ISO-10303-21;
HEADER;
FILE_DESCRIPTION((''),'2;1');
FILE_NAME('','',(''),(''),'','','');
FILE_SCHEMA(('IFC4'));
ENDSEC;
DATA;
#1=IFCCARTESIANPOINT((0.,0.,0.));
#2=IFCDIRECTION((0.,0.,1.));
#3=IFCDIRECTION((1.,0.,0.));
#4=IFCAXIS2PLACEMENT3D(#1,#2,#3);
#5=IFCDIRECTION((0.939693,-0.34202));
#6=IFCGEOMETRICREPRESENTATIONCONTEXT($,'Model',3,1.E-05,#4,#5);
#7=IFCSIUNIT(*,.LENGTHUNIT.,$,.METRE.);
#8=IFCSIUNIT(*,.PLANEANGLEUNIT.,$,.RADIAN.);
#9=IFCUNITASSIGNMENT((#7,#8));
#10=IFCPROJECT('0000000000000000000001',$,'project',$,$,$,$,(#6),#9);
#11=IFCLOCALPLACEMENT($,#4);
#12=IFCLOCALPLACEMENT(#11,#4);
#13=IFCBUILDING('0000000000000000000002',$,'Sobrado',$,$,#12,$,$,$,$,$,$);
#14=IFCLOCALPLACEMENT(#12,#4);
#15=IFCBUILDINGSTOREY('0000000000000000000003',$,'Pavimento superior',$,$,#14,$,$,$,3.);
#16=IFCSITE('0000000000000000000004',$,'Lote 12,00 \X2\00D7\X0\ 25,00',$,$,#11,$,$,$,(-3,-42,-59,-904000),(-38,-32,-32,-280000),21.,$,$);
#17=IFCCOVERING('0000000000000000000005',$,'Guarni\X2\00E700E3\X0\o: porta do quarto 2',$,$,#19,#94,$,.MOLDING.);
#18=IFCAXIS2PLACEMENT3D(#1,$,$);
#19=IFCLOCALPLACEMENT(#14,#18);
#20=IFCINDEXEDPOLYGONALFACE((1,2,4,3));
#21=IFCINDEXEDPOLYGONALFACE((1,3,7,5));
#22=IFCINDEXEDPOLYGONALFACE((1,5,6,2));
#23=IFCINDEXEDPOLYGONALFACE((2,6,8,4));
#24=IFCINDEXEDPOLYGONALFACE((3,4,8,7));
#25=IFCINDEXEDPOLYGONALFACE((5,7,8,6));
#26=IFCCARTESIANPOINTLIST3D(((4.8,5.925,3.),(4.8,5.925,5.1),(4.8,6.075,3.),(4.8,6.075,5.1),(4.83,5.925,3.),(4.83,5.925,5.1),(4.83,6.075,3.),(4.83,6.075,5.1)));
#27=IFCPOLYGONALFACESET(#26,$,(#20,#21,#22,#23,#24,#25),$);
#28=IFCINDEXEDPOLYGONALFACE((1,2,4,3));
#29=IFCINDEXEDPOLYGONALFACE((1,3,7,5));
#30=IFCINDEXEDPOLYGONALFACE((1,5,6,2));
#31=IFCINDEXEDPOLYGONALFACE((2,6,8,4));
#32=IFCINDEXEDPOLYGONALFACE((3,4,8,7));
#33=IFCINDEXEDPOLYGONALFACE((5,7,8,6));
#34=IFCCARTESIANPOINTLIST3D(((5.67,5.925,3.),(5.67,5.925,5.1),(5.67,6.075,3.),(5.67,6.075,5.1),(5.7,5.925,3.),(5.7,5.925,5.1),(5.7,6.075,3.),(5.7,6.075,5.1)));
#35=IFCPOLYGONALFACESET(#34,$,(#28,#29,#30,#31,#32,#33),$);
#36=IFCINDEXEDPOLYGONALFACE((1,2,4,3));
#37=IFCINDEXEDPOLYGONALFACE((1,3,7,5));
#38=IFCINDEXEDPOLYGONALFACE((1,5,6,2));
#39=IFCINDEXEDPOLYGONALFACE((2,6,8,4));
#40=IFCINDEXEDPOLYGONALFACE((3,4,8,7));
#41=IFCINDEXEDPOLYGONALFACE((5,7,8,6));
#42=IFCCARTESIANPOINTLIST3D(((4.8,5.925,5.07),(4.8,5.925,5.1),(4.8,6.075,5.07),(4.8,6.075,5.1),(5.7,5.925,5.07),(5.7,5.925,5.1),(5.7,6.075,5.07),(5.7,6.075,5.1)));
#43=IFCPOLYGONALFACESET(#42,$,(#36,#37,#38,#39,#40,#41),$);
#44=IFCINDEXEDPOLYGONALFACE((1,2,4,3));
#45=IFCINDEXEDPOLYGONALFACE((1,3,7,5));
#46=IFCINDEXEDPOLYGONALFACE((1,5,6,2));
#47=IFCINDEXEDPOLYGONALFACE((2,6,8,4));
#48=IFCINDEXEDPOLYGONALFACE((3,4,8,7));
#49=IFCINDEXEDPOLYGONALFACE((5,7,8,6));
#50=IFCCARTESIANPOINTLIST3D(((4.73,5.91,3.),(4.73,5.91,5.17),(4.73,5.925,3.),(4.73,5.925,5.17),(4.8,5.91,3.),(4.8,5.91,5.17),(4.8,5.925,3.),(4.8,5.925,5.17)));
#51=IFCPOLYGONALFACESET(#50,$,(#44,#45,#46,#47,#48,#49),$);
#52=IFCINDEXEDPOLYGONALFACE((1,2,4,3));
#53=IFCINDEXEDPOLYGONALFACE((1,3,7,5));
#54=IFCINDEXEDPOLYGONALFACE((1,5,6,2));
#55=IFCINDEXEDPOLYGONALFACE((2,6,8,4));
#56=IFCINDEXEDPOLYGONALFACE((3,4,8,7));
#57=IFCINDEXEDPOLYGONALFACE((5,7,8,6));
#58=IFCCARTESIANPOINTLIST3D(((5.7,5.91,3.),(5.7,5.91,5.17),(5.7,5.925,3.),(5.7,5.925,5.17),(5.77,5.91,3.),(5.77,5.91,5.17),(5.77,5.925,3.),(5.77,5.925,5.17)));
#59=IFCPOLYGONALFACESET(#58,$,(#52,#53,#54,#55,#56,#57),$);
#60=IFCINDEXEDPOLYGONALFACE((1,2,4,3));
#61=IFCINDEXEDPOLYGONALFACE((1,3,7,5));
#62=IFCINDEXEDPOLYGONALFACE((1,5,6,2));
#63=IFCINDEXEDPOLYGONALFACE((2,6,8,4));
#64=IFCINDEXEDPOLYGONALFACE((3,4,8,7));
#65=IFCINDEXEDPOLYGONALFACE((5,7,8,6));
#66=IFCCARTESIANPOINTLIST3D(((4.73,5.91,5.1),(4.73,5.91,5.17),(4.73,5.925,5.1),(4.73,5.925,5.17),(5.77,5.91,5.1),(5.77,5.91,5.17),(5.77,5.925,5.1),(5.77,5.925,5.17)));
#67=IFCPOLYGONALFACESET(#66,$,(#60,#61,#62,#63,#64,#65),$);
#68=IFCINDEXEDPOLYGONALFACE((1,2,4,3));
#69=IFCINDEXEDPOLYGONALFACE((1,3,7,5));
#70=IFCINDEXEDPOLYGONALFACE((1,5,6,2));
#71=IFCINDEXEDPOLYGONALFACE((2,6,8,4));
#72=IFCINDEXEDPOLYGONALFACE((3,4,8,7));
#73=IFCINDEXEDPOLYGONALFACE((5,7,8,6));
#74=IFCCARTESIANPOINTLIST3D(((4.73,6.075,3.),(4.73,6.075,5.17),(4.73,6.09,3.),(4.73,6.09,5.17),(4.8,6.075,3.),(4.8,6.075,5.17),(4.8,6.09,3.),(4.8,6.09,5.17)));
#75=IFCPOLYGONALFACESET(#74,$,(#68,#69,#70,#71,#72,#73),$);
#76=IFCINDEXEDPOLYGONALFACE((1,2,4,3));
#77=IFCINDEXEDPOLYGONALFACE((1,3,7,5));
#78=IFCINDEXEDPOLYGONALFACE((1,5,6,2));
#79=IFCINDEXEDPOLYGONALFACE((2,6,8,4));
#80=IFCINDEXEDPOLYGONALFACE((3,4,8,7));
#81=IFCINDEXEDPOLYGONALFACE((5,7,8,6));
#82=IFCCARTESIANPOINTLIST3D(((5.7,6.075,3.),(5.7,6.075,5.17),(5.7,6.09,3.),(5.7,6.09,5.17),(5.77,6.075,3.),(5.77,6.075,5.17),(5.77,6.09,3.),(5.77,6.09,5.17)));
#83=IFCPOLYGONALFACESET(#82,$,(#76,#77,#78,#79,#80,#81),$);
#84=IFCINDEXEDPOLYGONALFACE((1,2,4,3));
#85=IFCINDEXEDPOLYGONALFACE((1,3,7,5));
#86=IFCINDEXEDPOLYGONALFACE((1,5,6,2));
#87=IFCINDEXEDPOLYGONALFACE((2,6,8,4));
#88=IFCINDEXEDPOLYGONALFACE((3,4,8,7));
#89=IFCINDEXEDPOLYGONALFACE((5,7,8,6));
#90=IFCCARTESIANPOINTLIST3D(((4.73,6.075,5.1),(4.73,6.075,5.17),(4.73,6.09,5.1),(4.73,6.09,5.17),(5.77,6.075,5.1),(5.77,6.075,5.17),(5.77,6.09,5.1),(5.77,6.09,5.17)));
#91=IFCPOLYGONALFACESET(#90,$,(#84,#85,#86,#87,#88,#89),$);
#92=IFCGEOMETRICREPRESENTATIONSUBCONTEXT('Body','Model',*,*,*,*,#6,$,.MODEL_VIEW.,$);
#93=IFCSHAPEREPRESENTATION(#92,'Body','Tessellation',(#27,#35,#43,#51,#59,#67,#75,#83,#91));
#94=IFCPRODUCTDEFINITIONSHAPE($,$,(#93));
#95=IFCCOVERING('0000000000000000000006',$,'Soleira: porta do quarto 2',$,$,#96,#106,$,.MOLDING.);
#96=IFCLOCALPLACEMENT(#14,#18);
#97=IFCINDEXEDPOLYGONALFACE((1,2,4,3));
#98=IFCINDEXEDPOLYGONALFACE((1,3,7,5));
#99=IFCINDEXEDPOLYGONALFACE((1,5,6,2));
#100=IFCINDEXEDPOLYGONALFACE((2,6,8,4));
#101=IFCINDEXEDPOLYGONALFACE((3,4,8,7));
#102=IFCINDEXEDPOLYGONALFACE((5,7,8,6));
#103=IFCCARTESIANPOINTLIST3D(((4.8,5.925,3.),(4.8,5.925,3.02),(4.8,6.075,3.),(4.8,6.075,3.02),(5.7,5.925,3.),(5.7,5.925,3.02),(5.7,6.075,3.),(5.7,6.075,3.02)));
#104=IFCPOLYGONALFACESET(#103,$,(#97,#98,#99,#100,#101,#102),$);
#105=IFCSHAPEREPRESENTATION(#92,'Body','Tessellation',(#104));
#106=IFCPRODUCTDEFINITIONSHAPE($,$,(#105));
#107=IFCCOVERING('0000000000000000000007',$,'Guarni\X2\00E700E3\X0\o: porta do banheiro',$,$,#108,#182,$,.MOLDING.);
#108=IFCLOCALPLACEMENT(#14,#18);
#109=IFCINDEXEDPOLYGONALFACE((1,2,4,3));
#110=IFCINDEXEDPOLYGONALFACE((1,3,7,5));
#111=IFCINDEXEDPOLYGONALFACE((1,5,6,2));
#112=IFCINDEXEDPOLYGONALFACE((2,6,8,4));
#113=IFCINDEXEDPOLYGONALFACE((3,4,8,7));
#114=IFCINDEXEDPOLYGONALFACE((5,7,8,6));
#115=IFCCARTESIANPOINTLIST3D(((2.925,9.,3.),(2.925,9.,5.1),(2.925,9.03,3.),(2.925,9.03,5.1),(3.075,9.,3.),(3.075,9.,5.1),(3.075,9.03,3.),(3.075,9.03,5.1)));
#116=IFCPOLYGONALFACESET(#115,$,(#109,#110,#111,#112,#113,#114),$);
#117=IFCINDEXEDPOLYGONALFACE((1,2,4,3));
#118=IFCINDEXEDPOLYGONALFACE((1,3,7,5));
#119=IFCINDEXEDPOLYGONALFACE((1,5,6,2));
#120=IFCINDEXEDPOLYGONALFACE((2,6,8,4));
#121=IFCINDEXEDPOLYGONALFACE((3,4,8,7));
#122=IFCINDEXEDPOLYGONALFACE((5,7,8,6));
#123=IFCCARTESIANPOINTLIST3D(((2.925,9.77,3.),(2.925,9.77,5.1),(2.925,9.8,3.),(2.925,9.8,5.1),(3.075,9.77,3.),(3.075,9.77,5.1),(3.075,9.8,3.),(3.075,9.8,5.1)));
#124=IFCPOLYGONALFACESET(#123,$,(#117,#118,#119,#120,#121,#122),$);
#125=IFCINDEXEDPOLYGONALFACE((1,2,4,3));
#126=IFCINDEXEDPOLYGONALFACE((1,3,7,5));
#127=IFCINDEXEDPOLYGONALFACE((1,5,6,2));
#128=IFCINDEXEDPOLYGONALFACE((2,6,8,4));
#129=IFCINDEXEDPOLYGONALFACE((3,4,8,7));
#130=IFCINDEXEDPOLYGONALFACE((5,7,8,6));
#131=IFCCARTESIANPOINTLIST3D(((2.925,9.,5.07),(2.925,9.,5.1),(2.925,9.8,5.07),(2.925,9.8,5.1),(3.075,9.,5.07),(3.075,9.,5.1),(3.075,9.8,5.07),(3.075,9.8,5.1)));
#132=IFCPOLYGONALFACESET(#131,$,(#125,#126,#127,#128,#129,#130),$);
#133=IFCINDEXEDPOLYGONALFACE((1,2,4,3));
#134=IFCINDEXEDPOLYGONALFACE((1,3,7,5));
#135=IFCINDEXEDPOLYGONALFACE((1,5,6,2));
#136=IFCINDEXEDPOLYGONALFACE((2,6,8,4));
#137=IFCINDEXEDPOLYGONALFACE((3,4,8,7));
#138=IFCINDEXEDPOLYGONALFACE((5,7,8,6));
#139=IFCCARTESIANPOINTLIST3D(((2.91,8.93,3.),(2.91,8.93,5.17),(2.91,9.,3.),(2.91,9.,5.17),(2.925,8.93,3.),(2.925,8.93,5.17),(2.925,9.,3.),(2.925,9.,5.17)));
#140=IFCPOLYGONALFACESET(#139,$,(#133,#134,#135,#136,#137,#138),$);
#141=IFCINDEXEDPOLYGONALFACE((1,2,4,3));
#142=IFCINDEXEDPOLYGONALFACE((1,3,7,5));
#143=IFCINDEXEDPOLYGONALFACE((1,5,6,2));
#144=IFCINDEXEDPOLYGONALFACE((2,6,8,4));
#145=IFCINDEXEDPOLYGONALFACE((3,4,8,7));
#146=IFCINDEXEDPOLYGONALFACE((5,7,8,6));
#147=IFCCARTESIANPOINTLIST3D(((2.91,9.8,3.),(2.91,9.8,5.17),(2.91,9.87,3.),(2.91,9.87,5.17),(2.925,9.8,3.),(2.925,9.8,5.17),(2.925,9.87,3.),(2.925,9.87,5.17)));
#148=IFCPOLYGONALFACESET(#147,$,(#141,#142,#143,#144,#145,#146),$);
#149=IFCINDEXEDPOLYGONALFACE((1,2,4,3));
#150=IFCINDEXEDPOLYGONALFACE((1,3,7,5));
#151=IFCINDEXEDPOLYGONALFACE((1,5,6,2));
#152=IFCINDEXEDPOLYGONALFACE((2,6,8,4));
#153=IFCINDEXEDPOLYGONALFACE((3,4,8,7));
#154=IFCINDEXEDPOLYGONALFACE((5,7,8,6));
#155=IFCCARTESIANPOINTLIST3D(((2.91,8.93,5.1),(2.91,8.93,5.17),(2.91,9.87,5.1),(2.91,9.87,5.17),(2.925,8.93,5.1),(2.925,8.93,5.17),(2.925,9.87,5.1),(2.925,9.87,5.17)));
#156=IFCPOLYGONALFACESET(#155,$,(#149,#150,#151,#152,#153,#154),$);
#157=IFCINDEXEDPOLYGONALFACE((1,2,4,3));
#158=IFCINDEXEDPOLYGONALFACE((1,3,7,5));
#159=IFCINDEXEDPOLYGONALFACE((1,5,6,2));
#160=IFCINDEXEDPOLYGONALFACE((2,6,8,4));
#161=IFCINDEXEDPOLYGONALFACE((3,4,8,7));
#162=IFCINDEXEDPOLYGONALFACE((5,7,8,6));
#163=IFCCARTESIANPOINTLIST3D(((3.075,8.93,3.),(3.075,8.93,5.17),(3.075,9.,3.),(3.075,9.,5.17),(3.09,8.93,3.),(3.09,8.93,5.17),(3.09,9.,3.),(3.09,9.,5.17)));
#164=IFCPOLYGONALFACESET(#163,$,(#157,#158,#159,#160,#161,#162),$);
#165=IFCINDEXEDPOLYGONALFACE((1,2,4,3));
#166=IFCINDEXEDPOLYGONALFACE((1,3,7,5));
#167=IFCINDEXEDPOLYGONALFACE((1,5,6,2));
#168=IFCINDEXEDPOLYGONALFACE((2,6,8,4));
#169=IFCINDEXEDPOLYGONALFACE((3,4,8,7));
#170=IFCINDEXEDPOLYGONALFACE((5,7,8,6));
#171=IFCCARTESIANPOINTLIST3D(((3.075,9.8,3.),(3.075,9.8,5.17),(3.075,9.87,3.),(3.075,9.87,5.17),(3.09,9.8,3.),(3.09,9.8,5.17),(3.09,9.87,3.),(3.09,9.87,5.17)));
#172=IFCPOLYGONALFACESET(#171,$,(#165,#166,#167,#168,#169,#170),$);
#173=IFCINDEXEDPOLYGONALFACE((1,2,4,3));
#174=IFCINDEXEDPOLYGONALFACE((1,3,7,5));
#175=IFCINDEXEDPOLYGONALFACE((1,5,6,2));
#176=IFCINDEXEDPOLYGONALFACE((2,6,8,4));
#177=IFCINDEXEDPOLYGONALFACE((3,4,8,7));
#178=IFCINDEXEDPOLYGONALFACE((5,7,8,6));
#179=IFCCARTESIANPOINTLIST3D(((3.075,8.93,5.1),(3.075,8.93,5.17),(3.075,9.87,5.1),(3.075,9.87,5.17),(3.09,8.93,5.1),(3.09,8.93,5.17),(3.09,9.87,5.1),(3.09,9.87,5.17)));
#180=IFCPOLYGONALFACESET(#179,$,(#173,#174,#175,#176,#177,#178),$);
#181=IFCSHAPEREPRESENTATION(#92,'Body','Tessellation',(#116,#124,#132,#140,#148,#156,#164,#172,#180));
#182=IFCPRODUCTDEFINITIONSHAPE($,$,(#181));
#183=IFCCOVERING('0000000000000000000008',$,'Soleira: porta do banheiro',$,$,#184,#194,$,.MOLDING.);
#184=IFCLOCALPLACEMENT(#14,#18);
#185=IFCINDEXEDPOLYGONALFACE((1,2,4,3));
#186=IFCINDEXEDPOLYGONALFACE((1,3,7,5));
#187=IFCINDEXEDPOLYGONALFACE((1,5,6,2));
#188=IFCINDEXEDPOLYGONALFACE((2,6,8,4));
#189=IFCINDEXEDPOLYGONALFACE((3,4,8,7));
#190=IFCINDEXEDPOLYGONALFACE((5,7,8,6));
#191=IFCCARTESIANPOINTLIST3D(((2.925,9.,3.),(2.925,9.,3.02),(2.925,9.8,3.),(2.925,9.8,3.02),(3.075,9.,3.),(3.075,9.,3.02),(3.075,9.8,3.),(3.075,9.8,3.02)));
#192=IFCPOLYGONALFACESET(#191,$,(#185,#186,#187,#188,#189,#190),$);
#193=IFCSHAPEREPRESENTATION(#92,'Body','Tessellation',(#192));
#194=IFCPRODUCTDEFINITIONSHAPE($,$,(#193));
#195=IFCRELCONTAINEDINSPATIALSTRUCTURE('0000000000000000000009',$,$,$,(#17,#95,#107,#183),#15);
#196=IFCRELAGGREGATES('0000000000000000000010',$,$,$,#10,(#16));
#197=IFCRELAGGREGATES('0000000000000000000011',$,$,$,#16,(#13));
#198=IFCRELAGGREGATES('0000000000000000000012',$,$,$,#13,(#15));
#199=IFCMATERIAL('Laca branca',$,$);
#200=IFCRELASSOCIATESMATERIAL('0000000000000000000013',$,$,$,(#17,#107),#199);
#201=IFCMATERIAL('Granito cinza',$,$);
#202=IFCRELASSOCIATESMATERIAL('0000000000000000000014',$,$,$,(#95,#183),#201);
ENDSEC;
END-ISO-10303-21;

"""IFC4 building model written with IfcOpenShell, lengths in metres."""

from ifc_helpers import new_model, si_unit, direction, frame, origin_with_axes, place, context, subcontext, project, spatial, line, indexed_curve, outline, extrude, material, element, save


model = new_model("IFC4")

# Units and contexts
model_context = context("Model", 3, precision=1e-05, world=origin_with_axes(), true_north=direction((0.939693, -0.34202)))
body_context = subcontext(model_context, "Body", "Model", "MODEL_VIEW")
ifc_project = project(units=[si_unit("LENGTHUNIT", "METRE"), si_unit("PLANEANGLEUNIT", "RADIAN")], contexts=[model_context])

# Site, building, storey
site_placement = place(None, origin_with_axes())
site = spatial("IfcSite", under=ifc_project, at=site_placement, Name="Lote 12,00 × 25,00", RefLatitude=(-3, -42, -59, -904000), RefLongitude=(-38, -32, -32, -280000), RefElevation=21.0)
building_placement = place(site_placement, origin_with_axes())
building = spatial("IfcBuilding", under=site, at=building_placement, Name="Sobrado")
storey_placement = place(building_placement, origin_with_axes())
storey = spatial("IfcBuildingStorey", under=building, at=storey_placement, Name="Pavimento superior", Elevation=3.0)

# Coverings
ifc_material_1 = material(Name="Granito cinza")
ifc_material_2 = material(Name="Laca branca")
covering_1_placement = place(storey_placement, origin_with_axes())
element("IfcCovering", 1, at=covering_1_placement, inside=storey, material=ifc_material_2, Name="Guarnição: porta do quarto 2", PredefinedType="MOLDING", context=body_context, shape_type="SweptSolid", body=[
    extrude(outline(indexed_curve([(4.8, 5.925), (4.83, 5.925), (4.83, 6.075), (4.8, 6.075)], segments=[line(1, 2, 3, 4, 1)])), frame((0.0, 0.0, 3.0), z_axis=(0.0, 0.0, 1.0), x_axis=(1.0, 0.0, 0.0)), (0.0, 0.0, 1.0), 2.1),
    extrude(outline(indexed_curve([(5.67, 5.925), (5.7, 5.925), (5.7, 6.075), (5.67, 6.075)], segments=[line(1, 2, 3, 4, 1)])), frame((0.0, 0.0, 3.0), z_axis=(0.0, 0.0, 1.0), x_axis=(1.0, 0.0, 0.0)), (0.0, 0.0, 1.0), 2.1),
    extrude(outline(indexed_curve([(4.8, 5.925), (5.7, 5.925), (5.7, 6.075), (4.8, 6.075)], segments=[line(1, 2, 3, 4, 1)])), frame((0.0, 0.0, 5.07), z_axis=(0.0, 0.0, 1.0), x_axis=(1.0, 0.0, 0.0)), (0.0, 0.0, 1.0), 0.03),
    extrude(outline(indexed_curve([(4.73, 5.91), (4.8, 5.91), (4.8, 5.925), (4.73, 5.925)], segments=[line(1, 2, 3, 4, 1)])), frame((0.0, 0.0, 3.0), z_axis=(0.0, 0.0, 1.0), x_axis=(1.0, 0.0, 0.0)), (0.0, 0.0, 1.0), 2.17),
    extrude(outline(indexed_curve([(5.7, 5.91), (5.77, 5.91), (5.77, 5.925), (5.7, 5.925)], segments=[line(1, 2, 3, 4, 1)])), frame((0.0, 0.0, 3.0), z_axis=(0.0, 0.0, 1.0), x_axis=(1.0, 0.0, 0.0)), (0.0, 0.0, 1.0), 2.17),
    extrude(outline(indexed_curve([(4.73, 5.91), (5.77, 5.91), (5.77, 5.925), (4.73, 5.925)], segments=[line(1, 2, 3, 4, 1)])), frame((0.0, 0.0, 5.1), z_axis=(0.0, 0.0, 1.0), x_axis=(1.0, 0.0, 0.0)), (0.0, 0.0, 1.0), 0.07),
    extrude(outline(indexed_curve([(4.73, 6.075), (4.8, 6.075), (4.8, 6.09), (4.73, 6.09)], segments=[line(1, 2, 3, 4, 1)])), frame((0.0, 0.0, 3.0), z_axis=(0.0, 0.0, 1.0), x_axis=(1.0, 0.0, 0.0)), (0.0, 0.0, 1.0), 2.17),
    extrude(outline(indexed_curve([(5.7, 6.075), (5.77, 6.075), (5.77, 6.09), (5.7, 6.09)], segments=[line(1, 2, 3, 4, 1)])), frame((0.0, 0.0, 3.0), z_axis=(0.0, 0.0, 1.0), x_axis=(1.0, 0.0, 0.0)), (0.0, 0.0, 1.0), 2.17),
    extrude(outline(indexed_curve([(4.73, 6.075), (5.77, 6.075), (5.77, 6.09), (4.73, 6.09)], segments=[line(1, 2, 3, 4, 1)])), frame((0.0, 0.0, 5.1), z_axis=(0.0, 0.0, 1.0), x_axis=(1.0, 0.0, 0.0)), (0.0, 0.0, 1.0), 0.07),
])
covering_2_placement = place(storey_placement, origin_with_axes())
element("IfcCovering", 2, at=covering_2_placement, inside=storey, material=ifc_material_1, Name="Soleira: porta do quarto 2", PredefinedType="MOLDING", context=body_context, shape_type="SweptSolid", body=[
    extrude(outline(indexed_curve([(4.8, 5.925), (5.7, 5.925), (5.7, 6.075), (4.8, 6.075)], segments=[line(1, 2, 3, 4, 1)])), frame((0.0, 0.0, 3.0), z_axis=(0.0, 0.0, 1.0), x_axis=(1.0, 0.0, 0.0)), (0.0, 0.0, 1.0), 0.02),
])
covering_3_placement = place(storey_placement, origin_with_axes())
element("IfcCovering", 3, at=covering_3_placement, inside=storey, material=ifc_material_2, Name="Guarnição: porta do banheiro", PredefinedType="MOLDING", context=body_context, shape_type="SweptSolid", body=[
    extrude(outline(indexed_curve([(2.925, 9.0), (3.075, 9.0), (3.075, 9.03), (2.925, 9.03)], segments=[line(1, 2, 3, 4, 1)])), frame((0.0, 0.0, 3.0), z_axis=(0.0, 0.0, 1.0), x_axis=(1.0, 0.0, 0.0)), (0.0, 0.0, 1.0), 2.1),
    extrude(outline(indexed_curve([(2.925, 9.77), (3.075, 9.77), (3.075, 9.8), (2.925, 9.8)], segments=[line(1, 2, 3, 4, 1)])), frame((0.0, 0.0, 3.0), z_axis=(0.0, 0.0, 1.0), x_axis=(1.0, 0.0, 0.0)), (0.0, 0.0, 1.0), 2.1),
    extrude(outline(indexed_curve([(2.925, 9.0), (3.075, 9.0), (3.075, 9.8), (2.925, 9.8)], segments=[line(1, 2, 3, 4, 1)])), frame((0.0, 0.0, 5.07), z_axis=(0.0, 0.0, 1.0), x_axis=(1.0, 0.0, 0.0)), (0.0, 0.0, 1.0), 0.03),
    extrude(outline(indexed_curve([(2.91, 8.93), (2.925, 8.93), (2.925, 9.0), (2.91, 9.0)], segments=[line(1, 2, 3, 4, 1)])), frame((0.0, 0.0, 3.0), z_axis=(0.0, 0.0, 1.0), x_axis=(1.0, 0.0, 0.0)), (0.0, 0.0, 1.0), 2.17),
    extrude(outline(indexed_curve([(2.91, 9.8), (2.925, 9.8), (2.925, 9.87), (2.91, 9.87)], segments=[line(1, 2, 3, 4, 1)])), frame((0.0, 0.0, 3.0), z_axis=(0.0, 0.0, 1.0), x_axis=(1.0, 0.0, 0.0)), (0.0, 0.0, 1.0), 2.17),
    extrude(outline(indexed_curve([(2.91, 8.93), (2.925, 8.93), (2.925, 9.87), (2.91, 9.87)], segments=[line(1, 2, 3, 4, 1)])), frame((0.0, 0.0, 5.1), z_axis=(0.0, 0.0, 1.0), x_axis=(1.0, 0.0, 0.0)), (0.0, 0.0, 1.0), 0.07),
    extrude(outline(indexed_curve([(3.075, 8.93), (3.09, 8.93), (3.09, 9.0), (3.075, 9.0)], segments=[line(1, 2, 3, 4, 1)])), frame((0.0, 0.0, 3.0), z_axis=(0.0, 0.0, 1.0), x_axis=(1.0, 0.0, 0.0)), (0.0, 0.0, 1.0), 2.17),
    extrude(outline(indexed_curve([(3.075, 9.8), (3.09, 9.8), (3.09, 9.87), (3.075, 9.87)], segments=[line(1, 2, 3, 4, 1)])), frame((0.0, 0.0, 3.0), z_axis=(0.0, 0.0, 1.0), x_axis=(1.0, 0.0, 0.0)), (0.0, 0.0, 1.0), 2.17),
    extrude(outline(indexed_curve([(3.075, 8.93), (3.09, 8.93), (3.09, 9.87), (3.075, 9.87)], segments=[line(1, 2, 3, 4, 1)])), frame((0.0, 0.0, 5.1), z_axis=(0.0, 0.0, 1.0), x_axis=(1.0, 0.0, 0.0)), (0.0, 0.0, 1.0), 0.07),
])
covering_4_placement = place(storey_placement, origin_with_axes())
element("IfcCovering", 4, at=covering_4_placement, inside=storey, material=ifc_material_1, Name="Soleira: porta do banheiro", PredefinedType="MOLDING", context=body_context, shape_type="SweptSolid", body=[
    extrude(outline(indexed_curve([(2.925, 9.0), (3.075, 9.0), (3.075, 9.8), (2.925, 9.8)], segments=[line(1, 2, 3, 4, 1)])), frame((0.0, 0.0, 3.0), z_axis=(0.0, 0.0, 1.0), x_axis=(1.0, 0.0, 0.0)), (0.0, 0.0, 1.0), 0.02),
])

save(model, "model.ifc")
